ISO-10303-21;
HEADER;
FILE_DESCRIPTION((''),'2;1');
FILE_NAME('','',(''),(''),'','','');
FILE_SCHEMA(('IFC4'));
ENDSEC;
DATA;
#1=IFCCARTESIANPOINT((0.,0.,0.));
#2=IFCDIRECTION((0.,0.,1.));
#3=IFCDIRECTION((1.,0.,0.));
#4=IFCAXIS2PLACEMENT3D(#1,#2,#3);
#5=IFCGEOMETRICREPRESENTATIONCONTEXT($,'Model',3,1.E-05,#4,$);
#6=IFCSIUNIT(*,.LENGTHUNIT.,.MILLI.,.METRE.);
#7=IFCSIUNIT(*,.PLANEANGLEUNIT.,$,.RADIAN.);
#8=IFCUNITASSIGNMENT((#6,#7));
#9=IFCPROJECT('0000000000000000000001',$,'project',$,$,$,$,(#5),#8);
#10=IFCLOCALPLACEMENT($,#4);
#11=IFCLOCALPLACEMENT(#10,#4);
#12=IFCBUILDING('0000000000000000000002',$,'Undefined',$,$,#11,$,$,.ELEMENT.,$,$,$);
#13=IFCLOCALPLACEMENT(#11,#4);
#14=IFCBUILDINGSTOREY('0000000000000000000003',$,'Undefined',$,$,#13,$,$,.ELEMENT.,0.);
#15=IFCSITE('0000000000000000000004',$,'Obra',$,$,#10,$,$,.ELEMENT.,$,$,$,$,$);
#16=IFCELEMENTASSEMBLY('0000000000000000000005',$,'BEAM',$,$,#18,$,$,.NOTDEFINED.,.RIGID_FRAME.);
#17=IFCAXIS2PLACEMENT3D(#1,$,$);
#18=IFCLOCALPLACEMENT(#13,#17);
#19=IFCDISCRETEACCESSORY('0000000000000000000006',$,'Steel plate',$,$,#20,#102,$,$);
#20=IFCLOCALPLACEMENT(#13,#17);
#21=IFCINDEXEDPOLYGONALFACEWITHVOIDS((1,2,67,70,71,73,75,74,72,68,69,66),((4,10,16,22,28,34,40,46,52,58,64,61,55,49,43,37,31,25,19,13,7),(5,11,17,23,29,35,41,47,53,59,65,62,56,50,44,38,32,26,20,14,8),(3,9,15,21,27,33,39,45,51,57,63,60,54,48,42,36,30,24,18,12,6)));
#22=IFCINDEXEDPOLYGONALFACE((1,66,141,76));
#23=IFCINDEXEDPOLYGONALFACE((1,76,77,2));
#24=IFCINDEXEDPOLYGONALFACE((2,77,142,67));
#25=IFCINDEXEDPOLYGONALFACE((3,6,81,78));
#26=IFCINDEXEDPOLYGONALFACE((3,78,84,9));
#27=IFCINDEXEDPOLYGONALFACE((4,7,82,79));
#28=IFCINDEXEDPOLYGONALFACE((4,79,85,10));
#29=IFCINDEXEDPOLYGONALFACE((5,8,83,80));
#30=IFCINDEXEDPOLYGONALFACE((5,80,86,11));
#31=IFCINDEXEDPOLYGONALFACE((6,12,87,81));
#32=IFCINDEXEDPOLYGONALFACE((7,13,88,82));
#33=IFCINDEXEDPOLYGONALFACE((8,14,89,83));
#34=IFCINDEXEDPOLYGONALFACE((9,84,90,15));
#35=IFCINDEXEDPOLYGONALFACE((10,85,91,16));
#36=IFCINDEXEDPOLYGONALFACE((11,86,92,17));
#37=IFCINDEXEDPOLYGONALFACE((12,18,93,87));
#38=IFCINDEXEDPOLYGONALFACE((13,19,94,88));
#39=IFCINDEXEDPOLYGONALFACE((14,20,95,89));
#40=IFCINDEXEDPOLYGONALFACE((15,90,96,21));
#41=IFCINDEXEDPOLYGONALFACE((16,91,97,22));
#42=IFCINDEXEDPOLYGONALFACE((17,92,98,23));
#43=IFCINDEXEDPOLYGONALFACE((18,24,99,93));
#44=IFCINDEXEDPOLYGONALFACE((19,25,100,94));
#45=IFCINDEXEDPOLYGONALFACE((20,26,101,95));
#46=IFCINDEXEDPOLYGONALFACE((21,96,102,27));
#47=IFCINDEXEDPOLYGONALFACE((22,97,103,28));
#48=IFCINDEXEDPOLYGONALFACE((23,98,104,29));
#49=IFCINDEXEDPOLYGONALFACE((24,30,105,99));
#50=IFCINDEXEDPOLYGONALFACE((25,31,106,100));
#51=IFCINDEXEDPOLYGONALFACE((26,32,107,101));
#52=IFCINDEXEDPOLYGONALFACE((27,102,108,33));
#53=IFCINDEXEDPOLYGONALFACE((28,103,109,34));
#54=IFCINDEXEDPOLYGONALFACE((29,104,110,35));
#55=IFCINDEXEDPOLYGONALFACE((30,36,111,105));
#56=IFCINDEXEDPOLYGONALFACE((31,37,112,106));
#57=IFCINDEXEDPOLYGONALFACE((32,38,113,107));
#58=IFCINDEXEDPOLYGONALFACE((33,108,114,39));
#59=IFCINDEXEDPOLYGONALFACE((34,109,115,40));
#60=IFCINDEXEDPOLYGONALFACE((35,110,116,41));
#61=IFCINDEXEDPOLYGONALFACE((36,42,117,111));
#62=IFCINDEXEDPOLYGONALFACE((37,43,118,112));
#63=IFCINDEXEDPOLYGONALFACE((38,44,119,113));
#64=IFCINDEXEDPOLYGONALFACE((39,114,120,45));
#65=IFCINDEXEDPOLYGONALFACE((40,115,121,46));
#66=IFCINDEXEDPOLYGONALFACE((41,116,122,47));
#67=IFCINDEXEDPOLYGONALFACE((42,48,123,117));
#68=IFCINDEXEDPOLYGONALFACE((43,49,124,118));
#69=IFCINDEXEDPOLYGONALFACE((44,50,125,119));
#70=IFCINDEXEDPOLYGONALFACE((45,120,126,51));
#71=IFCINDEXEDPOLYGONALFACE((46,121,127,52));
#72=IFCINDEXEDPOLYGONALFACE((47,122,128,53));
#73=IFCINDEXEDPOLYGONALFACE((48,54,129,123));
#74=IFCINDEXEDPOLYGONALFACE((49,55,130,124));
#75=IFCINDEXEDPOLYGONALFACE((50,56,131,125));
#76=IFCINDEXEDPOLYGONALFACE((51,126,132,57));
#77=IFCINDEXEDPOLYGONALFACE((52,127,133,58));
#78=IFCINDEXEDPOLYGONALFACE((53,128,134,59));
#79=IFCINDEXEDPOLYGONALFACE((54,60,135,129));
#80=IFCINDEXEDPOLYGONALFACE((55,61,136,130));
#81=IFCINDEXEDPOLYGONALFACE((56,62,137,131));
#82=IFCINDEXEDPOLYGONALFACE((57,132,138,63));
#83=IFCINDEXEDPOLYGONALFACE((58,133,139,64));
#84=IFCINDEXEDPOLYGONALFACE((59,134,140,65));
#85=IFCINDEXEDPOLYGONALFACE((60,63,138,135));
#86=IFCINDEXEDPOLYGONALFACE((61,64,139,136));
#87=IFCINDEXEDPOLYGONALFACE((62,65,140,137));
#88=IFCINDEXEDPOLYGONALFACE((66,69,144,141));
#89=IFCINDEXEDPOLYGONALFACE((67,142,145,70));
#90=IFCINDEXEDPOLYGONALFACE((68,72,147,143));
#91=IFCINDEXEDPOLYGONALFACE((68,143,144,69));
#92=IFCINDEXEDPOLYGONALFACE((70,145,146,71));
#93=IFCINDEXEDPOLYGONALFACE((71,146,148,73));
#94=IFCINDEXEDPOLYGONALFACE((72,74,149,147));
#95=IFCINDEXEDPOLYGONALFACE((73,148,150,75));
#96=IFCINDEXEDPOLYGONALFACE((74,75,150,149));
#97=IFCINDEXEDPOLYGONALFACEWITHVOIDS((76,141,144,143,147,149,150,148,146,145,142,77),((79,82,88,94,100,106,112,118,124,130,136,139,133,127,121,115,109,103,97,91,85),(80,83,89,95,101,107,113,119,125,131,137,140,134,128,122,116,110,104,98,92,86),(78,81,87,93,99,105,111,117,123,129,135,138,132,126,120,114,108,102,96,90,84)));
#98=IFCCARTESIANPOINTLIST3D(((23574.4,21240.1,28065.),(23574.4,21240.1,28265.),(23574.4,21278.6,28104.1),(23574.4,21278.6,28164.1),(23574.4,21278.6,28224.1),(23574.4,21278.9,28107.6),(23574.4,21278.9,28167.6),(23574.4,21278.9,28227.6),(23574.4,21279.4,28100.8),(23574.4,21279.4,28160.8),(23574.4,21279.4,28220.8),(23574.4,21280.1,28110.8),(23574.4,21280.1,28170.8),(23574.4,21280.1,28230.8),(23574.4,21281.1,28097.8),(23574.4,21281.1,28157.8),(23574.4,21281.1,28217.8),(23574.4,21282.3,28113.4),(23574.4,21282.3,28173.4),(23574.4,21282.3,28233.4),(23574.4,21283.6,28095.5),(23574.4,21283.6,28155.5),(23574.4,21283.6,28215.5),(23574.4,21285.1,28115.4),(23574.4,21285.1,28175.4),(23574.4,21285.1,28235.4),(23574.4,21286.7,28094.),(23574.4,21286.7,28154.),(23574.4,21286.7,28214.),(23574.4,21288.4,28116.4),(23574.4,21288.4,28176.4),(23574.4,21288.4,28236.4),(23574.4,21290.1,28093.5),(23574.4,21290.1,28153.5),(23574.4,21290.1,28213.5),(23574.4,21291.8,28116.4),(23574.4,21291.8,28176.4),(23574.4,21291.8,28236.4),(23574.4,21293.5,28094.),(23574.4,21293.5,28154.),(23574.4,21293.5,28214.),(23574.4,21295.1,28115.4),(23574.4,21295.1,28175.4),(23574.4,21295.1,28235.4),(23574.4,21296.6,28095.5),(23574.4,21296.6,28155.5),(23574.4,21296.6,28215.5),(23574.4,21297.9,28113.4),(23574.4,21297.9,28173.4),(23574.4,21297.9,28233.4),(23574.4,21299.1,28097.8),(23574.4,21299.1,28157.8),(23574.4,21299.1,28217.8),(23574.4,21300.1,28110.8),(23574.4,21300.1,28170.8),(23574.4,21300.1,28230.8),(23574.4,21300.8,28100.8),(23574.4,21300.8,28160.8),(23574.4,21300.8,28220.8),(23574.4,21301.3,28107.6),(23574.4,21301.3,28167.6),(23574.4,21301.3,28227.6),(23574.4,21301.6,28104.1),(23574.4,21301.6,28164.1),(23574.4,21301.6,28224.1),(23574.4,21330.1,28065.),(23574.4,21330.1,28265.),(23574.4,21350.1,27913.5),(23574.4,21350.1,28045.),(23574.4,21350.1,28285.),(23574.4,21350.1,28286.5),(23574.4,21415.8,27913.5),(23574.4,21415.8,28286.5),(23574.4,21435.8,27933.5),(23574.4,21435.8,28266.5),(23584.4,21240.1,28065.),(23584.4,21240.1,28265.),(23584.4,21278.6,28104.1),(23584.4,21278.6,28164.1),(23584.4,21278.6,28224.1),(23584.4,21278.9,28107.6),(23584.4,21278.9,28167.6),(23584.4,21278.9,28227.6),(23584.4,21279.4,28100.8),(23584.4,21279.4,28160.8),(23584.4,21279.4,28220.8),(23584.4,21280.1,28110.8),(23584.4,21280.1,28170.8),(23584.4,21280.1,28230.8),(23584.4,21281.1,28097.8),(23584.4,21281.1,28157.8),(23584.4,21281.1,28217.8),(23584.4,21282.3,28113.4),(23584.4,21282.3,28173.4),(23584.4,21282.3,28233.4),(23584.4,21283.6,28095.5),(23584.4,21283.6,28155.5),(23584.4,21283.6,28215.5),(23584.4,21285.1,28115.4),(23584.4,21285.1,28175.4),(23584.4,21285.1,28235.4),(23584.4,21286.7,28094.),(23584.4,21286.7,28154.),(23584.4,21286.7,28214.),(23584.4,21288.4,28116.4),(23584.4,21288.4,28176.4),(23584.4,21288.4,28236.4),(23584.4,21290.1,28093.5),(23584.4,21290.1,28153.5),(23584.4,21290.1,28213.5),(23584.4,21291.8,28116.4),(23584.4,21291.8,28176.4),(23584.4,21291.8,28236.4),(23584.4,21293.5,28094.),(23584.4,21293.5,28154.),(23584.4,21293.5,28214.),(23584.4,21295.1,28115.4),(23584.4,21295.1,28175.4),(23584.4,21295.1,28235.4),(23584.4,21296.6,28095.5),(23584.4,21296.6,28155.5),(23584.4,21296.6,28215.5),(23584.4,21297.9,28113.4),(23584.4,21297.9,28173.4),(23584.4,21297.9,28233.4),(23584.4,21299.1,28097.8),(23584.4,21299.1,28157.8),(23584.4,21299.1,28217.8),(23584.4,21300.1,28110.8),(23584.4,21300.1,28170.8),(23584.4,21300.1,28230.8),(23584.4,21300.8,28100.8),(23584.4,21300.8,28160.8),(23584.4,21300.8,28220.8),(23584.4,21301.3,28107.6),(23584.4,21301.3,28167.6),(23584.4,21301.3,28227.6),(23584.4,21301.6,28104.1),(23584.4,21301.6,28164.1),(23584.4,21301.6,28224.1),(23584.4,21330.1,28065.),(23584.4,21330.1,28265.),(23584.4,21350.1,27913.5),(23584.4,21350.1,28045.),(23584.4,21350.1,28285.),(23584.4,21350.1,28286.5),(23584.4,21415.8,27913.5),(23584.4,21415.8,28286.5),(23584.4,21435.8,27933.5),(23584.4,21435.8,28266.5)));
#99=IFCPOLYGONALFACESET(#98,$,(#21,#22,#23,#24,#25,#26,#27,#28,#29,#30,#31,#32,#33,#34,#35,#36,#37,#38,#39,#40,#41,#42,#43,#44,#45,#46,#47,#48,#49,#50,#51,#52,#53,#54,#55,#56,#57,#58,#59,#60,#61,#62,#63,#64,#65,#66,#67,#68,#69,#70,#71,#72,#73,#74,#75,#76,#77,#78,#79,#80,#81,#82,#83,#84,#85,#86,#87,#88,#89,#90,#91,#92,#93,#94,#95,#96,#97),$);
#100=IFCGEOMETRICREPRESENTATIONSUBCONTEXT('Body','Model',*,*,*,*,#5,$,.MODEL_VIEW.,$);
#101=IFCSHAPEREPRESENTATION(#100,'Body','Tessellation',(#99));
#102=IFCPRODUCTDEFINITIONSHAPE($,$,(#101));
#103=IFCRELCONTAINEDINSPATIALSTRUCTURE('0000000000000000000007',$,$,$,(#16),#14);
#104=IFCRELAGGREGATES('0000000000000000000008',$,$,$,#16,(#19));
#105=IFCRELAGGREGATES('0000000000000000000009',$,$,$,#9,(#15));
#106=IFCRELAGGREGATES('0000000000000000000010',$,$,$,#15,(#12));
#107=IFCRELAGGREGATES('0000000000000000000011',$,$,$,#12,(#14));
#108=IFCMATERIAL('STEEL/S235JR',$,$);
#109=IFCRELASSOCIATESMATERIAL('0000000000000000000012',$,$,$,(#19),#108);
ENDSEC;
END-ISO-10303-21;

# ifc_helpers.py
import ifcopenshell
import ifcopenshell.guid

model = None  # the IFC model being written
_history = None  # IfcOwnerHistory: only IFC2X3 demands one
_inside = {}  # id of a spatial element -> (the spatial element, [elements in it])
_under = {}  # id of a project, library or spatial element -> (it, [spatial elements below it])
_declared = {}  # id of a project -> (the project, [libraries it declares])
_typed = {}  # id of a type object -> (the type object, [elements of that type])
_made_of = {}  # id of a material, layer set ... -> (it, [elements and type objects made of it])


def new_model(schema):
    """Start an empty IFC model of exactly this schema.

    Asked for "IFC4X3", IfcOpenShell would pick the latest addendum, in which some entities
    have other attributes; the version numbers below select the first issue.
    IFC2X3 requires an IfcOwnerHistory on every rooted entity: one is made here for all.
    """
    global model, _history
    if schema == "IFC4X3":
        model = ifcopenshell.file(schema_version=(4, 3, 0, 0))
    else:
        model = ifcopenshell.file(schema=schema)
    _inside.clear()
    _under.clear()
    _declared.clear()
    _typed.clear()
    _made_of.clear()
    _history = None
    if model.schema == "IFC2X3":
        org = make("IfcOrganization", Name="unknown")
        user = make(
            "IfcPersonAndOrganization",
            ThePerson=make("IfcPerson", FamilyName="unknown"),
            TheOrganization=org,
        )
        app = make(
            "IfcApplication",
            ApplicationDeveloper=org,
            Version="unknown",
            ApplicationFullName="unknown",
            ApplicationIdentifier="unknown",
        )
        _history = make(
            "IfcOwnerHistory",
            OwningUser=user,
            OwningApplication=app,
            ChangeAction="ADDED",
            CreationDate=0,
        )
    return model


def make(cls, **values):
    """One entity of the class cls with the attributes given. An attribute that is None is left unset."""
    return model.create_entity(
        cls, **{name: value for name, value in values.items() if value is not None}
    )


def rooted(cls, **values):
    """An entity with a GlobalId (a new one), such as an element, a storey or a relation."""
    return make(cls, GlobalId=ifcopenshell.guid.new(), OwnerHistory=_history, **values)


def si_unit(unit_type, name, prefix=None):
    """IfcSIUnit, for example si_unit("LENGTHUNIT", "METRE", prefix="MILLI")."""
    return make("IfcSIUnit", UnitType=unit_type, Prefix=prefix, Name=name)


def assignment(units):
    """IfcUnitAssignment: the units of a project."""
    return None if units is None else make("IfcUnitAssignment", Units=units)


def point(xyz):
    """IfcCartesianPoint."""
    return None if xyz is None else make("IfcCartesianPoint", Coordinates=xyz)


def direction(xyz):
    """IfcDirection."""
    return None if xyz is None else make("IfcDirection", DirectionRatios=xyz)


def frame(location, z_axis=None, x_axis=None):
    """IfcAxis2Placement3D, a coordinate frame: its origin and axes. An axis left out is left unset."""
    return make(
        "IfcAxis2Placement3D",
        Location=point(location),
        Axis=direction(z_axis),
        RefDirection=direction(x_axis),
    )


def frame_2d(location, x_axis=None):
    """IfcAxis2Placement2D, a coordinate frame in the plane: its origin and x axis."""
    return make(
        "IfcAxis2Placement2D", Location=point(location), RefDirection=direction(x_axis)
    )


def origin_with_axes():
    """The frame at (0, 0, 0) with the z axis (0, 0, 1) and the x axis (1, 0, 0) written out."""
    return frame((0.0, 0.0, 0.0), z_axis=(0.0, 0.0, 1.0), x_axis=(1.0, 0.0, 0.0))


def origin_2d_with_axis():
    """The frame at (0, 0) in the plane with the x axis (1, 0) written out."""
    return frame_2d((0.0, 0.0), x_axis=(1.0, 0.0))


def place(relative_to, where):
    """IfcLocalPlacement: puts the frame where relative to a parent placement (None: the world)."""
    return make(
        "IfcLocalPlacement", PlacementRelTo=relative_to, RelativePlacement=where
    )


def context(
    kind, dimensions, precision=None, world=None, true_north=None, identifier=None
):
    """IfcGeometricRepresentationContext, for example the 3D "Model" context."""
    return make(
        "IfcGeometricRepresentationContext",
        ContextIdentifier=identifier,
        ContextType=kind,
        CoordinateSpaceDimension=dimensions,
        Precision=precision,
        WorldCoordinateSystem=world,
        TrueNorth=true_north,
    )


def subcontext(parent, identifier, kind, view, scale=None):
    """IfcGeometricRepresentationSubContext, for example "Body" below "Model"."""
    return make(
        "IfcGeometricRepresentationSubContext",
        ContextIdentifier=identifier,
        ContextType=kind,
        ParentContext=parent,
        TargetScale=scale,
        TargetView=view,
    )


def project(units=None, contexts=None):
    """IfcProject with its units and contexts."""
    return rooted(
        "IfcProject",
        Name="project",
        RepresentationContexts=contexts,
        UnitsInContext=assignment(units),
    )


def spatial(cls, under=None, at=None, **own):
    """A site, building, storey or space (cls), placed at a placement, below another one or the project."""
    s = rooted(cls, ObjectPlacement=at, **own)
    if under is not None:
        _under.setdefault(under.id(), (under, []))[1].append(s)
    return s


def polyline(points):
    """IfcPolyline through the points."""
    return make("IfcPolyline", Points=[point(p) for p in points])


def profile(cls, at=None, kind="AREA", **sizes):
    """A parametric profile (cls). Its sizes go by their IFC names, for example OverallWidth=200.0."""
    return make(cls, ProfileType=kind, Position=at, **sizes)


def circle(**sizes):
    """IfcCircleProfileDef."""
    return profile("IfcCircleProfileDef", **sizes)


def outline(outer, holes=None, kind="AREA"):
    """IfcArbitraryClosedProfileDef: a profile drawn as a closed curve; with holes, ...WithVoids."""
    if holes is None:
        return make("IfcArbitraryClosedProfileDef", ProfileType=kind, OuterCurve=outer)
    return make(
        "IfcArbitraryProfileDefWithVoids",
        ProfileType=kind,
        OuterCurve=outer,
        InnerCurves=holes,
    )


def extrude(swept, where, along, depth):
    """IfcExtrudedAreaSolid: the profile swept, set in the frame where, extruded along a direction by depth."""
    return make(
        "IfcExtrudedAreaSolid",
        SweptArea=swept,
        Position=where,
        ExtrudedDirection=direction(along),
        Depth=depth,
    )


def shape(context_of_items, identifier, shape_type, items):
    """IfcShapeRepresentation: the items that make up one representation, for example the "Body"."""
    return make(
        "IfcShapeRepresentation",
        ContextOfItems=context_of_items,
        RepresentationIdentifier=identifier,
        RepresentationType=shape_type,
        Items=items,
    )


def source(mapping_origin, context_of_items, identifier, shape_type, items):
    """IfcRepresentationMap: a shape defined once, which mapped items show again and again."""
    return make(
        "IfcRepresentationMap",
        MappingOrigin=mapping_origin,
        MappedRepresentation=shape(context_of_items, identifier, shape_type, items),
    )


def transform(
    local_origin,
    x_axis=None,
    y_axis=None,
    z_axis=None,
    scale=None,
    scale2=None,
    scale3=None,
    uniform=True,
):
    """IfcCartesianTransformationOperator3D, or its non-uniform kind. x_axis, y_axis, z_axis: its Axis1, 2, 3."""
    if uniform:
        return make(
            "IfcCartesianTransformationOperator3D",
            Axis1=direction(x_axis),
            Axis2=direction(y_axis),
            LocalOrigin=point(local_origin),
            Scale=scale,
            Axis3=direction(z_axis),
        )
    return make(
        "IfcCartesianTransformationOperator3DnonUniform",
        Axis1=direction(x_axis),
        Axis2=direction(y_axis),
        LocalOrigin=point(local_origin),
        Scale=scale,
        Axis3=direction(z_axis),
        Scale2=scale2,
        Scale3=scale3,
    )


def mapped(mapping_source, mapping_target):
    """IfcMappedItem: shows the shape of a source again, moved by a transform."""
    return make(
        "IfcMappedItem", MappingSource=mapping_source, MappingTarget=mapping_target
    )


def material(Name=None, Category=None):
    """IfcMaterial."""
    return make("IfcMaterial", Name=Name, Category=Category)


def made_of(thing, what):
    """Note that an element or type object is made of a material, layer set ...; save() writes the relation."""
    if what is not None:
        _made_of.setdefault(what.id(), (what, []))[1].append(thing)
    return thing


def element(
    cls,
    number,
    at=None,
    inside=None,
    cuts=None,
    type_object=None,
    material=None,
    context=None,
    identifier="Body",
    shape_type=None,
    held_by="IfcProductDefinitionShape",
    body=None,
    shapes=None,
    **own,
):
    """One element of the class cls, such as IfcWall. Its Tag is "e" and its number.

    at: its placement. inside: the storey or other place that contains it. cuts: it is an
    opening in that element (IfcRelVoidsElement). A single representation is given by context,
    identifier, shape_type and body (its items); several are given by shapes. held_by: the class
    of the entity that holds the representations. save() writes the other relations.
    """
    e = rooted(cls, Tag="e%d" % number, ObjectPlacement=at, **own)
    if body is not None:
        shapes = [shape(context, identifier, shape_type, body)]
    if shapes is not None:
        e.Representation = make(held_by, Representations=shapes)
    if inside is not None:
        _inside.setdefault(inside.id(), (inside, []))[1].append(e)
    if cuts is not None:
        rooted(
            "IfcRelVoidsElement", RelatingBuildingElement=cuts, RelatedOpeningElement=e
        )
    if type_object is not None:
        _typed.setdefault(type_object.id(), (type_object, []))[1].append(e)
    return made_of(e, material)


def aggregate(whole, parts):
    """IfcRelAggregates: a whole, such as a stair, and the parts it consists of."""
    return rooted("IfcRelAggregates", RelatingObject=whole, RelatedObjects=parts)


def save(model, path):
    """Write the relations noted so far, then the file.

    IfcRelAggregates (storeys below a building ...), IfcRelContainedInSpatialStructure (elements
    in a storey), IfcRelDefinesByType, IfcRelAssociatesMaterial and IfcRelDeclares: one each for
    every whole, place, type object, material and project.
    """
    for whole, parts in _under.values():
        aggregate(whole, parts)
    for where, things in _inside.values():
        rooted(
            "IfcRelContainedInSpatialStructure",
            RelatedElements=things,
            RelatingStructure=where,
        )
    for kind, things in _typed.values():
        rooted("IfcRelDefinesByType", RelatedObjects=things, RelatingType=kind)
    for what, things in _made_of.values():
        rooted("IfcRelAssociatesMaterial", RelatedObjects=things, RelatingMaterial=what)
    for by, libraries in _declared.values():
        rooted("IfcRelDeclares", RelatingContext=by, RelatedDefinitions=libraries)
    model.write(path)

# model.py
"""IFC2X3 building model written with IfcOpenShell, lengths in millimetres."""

from ifc_helpers import new_model, si_unit, frame, origin_with_axes, origin_2d_with_axis, place, context, subcontext, project, spatial, polyline, circle, outline, extrude, source, transform, mapped, material, element, aggregate, save


model = new_model("IFC2X3")

# Units and contexts
model_context = context("Model", 3, precision=1e-05, world=origin_with_axes())
body_context = subcontext(model_context, "Body", "Model", "MODEL_VIEW")
ifc_project = project(units=[si_unit("LENGTHUNIT", "METRE", prefix="MILLI"), si_unit("PLANEANGLEUNIT", "RADIAN")], contexts=[model_context])

# Site, building, storey
site_placement = place(None, origin_with_axes())
site = spatial("IfcSite", under=ifc_project, at=site_placement, Name="Obra", CompositionType="ELEMENT")
building_placement = place(site_placement, origin_with_axes())
building = spatial("IfcBuilding", under=site, at=building_placement, Name="Undefined", CompositionType="ELEMENT")
storey_placement = place(building_placement, origin_with_axes())
storey = spatial("IfcBuildingStorey", under=building, at=storey_placement, Name="Undefined", CompositionType="ELEMENT", Elevation=0.0)

# Shared definitions
ifc_material = material(Name="STEEL/S235JR")

# Element assembly, discrete accessory, opening
assembly_1_placement = place(storey_placement, origin_with_axes())
assembly_1 = element("IfcElementAssembly", 1, at=assembly_1_placement, inside=storey, Name="BEAM", AssemblyPlace="NOTDEFINED", PredefinedType="RIGID_FRAME")
shared_shape_1 = source(origin_with_axes(), body_context, "Body", "SweptSolid", [
    extrude(circle(Radius=11.5, at=origin_2d_with_axis()), frame((0.0, -13.4, 0.0), z_axis=(0.0, 1.0, 0.0), x_axis=(1.0, 0.0, 0.0)), (0.0, 0.0, 1.0), 10.2),
])
discrete_accessory_1_placement = place(assembly_1_placement, frame((23579.4, 21435.8, 27933.5), z_axis=(-1.0, 0.0, 0.0), x_axis=(0.000001, -0.707107, -0.707107)))
discrete_accessory_1 = element("IfcDiscreteAccessory", 2, at=discrete_accessory_1_placement, material=ifc_material, Name="Steel plate", context=body_context, shape_type="SweptSolid", body=[
    extrude(outline(polyline([(0.0, 0.0), (28.3, 0.0), (74.7, 46.5), (-18.2, 139.4), (-18.2, 167.7), (45.4, 231.4), (-96.0, 372.8), (-159.7, 309.1), (-187.9, 309.1), (-189.0, 310.2), (-235.5, 263.8), (-235.5, 235.5), (0.0, 0.0)])), frame((0.0, 0.0, -5.0), z_axis=(0.0, 0.0, 1.0), x_axis=(1.0, 0.0, 0.0)), (0.0, 0.0, 1.0), 10.0),
])
opening_1_placement = place(assembly_1_placement, frame((23587.7, 21340.1, 28265.0), z_axis=(0.0, -1.0, 0.0), x_axis=(0.0, 0.0, -1.0)))
element("IfcOpeningElement", 3, at=opening_1_placement, cuts=discrete_accessory_1, ObjectType="Opening", context=body_context, shape_type="MappedRepresentation", body=[
    mapped(shared_shape_1, transform((40.0, 0.0, 50.0))),
    mapped(shared_shape_1, transform((100.0, 0.0, 50.0))),
    mapped(shared_shape_1, transform((160.0, 0.0, 50.0))),
])
aggregate(assembly_1, [discrete_accessory_1])

save(model, "model.ifc")
